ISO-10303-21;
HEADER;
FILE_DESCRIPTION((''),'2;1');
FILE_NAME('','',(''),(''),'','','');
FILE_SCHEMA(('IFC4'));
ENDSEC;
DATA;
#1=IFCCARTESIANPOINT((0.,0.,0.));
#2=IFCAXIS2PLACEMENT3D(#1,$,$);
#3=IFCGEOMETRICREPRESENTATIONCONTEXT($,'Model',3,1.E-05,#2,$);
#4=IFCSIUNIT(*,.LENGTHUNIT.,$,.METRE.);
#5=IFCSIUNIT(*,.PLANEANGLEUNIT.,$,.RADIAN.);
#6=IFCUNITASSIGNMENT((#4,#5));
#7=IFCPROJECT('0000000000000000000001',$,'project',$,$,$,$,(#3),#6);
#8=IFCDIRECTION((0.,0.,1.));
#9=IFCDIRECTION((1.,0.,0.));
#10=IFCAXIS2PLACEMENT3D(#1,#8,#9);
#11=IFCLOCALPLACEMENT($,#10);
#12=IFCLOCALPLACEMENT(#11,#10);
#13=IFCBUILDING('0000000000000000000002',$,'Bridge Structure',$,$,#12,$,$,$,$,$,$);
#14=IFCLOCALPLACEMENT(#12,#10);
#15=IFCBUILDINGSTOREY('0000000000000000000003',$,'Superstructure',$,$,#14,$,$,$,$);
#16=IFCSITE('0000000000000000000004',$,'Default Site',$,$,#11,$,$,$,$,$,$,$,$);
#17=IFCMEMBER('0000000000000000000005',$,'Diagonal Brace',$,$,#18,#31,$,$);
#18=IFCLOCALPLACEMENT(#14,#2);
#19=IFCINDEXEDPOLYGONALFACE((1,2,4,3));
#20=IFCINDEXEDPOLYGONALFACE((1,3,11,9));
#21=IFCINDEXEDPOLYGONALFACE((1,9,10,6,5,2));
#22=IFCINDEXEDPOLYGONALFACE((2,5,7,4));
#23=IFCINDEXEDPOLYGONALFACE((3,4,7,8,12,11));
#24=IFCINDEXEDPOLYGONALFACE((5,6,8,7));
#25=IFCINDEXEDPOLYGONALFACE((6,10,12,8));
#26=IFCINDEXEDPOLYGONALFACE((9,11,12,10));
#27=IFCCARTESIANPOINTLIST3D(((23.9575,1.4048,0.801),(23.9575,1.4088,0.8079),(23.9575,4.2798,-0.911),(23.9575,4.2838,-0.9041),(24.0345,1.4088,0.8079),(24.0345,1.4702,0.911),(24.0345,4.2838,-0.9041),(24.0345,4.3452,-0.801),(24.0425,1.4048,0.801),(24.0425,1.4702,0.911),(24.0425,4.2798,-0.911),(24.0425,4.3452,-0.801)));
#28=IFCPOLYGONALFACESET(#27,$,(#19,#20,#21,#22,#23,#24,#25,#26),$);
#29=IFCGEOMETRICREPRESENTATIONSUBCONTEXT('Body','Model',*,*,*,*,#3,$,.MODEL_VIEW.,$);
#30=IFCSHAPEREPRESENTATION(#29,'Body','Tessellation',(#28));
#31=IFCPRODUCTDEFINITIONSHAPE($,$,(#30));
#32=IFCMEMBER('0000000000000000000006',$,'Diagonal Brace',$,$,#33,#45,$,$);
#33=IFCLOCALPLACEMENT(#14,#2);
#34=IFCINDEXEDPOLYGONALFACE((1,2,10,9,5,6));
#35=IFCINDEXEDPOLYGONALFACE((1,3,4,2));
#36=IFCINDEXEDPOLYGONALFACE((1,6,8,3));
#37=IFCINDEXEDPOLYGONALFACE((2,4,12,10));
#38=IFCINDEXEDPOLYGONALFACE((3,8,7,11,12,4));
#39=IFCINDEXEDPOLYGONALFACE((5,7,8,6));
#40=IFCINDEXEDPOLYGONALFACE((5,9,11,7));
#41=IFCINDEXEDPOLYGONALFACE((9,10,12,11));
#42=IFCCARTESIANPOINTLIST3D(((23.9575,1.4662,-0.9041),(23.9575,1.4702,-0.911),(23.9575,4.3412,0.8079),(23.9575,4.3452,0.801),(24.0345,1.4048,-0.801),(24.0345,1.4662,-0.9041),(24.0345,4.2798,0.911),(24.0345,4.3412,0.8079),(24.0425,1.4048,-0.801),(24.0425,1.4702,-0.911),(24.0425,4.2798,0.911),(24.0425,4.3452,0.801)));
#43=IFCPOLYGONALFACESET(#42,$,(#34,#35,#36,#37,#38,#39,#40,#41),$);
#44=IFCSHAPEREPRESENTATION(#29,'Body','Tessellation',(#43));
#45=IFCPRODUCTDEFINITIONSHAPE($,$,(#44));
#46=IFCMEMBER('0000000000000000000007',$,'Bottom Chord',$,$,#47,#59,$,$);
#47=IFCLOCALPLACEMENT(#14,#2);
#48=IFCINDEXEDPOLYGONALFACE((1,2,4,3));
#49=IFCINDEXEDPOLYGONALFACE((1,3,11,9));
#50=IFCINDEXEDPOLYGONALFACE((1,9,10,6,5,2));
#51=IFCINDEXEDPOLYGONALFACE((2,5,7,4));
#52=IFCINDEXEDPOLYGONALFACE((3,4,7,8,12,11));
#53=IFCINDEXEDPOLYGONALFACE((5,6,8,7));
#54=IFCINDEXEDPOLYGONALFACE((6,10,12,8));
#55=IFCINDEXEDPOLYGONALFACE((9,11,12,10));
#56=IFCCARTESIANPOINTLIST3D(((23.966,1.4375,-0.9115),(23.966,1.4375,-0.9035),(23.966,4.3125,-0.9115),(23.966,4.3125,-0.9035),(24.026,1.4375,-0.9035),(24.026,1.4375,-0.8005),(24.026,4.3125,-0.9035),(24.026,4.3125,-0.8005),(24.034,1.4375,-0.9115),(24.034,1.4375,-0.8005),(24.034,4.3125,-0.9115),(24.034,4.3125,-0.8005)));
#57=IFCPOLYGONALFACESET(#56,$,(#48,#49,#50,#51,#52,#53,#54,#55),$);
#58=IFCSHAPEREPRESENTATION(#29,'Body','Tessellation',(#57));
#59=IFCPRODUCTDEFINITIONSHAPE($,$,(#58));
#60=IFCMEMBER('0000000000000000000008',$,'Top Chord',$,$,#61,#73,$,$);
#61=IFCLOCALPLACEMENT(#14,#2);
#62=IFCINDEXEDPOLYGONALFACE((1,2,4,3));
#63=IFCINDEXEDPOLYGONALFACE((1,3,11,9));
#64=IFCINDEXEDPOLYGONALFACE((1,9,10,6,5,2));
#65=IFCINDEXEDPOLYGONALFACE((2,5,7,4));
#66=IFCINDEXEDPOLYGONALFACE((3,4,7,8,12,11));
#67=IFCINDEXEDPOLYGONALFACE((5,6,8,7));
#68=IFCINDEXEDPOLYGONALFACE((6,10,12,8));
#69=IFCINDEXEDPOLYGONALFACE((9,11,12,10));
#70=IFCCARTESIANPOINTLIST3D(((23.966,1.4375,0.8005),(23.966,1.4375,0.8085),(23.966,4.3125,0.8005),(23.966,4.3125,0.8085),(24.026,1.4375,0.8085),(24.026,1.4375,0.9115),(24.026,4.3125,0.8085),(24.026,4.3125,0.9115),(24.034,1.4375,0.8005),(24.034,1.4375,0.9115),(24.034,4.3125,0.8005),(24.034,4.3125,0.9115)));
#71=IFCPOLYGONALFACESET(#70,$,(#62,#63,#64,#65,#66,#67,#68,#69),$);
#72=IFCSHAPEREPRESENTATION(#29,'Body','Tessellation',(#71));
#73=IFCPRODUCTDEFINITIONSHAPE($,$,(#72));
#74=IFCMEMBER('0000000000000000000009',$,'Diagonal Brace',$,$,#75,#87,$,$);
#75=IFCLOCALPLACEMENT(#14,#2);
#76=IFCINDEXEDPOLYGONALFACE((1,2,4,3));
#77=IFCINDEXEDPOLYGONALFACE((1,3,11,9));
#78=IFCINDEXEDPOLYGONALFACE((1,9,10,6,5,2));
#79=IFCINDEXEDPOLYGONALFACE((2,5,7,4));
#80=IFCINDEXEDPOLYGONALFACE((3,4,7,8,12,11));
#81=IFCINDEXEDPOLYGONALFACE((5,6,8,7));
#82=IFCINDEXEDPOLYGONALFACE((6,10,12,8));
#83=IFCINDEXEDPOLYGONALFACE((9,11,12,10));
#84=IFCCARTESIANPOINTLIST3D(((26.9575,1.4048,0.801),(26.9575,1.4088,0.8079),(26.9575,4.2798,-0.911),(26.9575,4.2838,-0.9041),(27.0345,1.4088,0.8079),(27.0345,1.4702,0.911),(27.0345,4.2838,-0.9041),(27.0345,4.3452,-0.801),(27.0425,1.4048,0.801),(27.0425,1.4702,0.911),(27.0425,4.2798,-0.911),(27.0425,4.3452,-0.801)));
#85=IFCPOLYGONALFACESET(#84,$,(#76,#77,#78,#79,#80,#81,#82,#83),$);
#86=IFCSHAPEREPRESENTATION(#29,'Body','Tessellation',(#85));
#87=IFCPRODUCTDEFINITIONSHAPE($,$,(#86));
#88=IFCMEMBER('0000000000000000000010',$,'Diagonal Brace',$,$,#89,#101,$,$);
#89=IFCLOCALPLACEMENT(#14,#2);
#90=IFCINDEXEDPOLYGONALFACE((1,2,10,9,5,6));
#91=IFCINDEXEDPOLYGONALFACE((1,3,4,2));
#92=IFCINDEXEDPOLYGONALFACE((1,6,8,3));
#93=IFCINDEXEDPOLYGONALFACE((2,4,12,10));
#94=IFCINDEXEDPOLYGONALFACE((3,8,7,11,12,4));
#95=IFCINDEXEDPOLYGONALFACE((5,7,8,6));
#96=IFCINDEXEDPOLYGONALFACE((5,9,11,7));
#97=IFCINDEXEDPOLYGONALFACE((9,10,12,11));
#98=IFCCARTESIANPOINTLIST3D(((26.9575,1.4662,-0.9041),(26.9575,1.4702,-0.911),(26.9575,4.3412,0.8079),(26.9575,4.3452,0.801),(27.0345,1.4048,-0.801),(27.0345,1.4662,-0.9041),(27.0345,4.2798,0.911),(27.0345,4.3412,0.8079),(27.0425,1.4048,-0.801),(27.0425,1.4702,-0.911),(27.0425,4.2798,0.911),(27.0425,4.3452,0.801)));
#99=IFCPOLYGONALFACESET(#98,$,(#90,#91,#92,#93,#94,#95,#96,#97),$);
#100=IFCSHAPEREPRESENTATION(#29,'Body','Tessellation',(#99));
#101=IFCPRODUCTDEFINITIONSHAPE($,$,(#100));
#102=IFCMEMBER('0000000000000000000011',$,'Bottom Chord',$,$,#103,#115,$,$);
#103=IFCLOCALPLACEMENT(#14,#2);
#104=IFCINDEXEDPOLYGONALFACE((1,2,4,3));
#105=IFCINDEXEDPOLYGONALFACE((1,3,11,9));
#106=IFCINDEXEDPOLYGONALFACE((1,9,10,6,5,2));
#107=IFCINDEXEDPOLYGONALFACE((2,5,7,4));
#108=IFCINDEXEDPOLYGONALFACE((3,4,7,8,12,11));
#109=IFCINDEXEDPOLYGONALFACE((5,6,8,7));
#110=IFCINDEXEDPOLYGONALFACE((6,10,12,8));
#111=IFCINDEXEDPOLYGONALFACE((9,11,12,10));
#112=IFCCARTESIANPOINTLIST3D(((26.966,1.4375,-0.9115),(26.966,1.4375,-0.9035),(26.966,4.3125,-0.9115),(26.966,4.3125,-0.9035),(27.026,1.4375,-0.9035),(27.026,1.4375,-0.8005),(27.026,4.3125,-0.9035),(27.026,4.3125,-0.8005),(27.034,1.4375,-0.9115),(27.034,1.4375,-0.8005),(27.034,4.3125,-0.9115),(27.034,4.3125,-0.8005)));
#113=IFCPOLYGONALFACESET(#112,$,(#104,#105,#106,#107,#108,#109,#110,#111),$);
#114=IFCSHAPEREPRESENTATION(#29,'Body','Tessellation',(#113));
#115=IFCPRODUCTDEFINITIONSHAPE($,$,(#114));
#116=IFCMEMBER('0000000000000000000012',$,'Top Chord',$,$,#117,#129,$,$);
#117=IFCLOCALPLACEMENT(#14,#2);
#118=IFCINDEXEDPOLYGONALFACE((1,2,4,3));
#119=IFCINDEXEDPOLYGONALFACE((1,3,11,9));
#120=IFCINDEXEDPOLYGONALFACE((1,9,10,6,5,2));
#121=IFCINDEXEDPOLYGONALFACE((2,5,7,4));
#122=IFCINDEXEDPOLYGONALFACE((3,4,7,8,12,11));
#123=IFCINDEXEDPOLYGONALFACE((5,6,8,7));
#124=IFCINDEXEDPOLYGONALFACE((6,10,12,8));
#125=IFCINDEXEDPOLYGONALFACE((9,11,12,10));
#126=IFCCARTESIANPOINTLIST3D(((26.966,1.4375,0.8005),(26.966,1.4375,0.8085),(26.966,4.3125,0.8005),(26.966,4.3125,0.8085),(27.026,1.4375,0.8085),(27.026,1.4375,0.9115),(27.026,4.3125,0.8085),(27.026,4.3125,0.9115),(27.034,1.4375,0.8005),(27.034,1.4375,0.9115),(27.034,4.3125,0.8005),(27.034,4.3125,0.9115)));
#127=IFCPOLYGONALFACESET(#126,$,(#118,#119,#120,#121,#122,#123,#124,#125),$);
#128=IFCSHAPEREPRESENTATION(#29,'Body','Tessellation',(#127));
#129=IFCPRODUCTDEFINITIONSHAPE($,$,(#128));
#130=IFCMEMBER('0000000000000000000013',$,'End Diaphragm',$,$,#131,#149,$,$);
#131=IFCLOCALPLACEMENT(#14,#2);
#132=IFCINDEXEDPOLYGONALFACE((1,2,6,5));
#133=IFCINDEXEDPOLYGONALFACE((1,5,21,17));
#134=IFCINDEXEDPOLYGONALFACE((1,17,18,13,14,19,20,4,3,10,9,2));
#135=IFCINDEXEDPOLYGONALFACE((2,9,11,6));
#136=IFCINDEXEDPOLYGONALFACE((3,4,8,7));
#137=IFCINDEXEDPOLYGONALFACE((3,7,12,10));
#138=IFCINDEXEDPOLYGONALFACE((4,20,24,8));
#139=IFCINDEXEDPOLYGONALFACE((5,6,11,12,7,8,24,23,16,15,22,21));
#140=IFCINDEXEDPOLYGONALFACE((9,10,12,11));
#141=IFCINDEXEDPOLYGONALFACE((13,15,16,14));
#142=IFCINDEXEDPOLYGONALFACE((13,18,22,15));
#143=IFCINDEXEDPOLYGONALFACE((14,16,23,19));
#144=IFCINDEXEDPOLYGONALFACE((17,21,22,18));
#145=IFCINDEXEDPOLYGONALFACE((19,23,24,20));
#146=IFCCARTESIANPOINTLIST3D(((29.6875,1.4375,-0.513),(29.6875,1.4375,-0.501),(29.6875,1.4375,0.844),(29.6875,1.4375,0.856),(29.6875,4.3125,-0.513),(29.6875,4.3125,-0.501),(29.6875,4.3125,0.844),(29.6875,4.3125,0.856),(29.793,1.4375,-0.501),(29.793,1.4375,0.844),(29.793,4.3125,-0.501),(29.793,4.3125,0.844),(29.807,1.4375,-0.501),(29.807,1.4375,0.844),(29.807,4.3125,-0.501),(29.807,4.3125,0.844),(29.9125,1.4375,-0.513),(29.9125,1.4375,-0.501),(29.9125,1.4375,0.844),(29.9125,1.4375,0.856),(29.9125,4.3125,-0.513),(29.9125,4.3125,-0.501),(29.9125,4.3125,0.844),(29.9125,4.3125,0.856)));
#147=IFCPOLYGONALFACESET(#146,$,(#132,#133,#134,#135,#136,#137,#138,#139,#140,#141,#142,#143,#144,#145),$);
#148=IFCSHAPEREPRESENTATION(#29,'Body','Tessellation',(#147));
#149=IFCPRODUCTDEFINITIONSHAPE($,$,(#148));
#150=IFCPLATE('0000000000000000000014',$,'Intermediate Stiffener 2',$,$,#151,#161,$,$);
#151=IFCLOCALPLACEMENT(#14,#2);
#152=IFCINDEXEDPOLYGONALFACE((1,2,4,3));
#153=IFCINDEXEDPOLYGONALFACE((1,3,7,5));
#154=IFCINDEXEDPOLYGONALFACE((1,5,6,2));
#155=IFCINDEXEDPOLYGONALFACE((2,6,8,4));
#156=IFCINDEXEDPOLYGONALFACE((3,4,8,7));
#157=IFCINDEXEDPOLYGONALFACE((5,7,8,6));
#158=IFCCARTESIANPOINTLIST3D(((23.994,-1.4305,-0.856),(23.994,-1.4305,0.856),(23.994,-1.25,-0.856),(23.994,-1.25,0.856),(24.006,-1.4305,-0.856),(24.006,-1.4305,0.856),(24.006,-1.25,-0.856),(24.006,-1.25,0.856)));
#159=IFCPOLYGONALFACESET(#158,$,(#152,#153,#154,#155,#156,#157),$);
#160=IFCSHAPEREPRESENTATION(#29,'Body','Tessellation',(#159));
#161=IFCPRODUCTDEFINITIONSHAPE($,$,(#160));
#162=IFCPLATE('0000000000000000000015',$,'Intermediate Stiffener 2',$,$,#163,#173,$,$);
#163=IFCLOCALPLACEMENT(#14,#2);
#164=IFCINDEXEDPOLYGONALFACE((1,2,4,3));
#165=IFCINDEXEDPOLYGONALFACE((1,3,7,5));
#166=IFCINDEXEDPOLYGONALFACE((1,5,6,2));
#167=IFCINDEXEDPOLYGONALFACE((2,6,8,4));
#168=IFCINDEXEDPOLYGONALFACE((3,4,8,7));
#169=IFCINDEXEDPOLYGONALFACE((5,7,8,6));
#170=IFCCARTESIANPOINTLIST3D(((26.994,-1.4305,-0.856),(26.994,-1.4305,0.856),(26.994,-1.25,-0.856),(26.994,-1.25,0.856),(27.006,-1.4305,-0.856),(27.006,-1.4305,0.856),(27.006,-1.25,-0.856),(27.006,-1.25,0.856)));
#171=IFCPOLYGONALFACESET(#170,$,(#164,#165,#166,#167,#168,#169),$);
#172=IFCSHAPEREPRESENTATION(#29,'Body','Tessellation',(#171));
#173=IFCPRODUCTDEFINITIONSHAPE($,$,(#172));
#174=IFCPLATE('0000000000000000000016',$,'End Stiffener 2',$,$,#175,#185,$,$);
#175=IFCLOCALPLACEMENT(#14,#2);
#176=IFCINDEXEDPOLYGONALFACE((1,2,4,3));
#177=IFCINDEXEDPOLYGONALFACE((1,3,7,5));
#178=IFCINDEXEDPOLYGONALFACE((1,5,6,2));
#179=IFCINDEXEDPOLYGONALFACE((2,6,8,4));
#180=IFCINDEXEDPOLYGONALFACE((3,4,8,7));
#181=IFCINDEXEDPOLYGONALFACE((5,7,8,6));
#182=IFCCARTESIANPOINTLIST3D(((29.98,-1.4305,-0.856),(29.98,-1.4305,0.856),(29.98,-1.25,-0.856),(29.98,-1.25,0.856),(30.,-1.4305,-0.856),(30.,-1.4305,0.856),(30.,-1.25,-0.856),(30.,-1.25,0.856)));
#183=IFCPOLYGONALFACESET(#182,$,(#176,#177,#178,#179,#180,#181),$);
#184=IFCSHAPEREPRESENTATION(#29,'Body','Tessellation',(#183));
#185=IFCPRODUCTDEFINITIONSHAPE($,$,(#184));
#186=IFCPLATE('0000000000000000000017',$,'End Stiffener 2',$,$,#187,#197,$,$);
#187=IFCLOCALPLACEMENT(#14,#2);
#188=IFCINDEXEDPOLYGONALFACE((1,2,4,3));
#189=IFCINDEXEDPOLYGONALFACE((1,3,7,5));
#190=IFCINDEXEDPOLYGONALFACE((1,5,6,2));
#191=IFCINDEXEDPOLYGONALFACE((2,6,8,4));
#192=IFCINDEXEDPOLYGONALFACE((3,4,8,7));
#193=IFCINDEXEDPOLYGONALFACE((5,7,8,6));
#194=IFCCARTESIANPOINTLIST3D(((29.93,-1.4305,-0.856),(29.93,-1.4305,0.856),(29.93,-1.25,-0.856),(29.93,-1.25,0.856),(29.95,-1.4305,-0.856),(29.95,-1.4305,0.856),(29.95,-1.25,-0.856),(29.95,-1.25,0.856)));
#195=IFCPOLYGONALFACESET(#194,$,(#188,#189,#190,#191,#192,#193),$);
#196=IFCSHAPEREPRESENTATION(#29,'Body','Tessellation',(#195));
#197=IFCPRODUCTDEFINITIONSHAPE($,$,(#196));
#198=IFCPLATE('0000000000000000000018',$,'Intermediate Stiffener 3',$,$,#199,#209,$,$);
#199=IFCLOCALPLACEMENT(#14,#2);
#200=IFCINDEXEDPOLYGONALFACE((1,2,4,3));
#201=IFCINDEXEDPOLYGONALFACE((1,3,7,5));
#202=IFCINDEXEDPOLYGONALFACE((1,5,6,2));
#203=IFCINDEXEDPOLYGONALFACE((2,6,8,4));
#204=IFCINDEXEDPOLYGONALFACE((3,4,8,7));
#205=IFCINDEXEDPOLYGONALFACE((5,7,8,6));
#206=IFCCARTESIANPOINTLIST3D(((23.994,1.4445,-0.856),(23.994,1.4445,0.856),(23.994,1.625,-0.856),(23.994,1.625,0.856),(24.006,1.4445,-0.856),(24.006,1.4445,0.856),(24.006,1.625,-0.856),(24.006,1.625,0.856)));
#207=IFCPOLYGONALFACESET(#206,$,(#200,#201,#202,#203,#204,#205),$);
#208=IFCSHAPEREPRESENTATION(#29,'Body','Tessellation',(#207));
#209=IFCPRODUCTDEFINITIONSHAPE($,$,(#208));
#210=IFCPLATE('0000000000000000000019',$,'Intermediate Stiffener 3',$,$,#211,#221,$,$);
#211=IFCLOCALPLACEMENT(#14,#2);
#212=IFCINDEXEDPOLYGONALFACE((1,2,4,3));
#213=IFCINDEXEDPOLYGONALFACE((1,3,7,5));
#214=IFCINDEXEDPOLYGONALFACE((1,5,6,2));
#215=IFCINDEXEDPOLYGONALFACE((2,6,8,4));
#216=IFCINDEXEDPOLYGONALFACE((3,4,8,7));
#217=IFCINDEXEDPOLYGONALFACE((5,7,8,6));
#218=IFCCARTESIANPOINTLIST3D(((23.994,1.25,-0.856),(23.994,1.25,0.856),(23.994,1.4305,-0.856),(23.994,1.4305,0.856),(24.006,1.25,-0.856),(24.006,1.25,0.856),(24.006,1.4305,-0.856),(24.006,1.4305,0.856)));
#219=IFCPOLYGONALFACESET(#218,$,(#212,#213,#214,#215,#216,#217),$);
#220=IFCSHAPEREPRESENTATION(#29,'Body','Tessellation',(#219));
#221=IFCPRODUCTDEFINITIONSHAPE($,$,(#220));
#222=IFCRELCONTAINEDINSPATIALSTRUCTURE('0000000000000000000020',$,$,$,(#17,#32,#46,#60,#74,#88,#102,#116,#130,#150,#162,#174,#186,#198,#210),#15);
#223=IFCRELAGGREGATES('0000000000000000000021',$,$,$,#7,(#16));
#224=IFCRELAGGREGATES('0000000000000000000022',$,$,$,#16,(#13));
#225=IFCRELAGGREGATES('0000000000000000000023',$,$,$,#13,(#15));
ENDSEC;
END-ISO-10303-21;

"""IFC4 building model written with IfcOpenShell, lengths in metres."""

from ifc_helpers import new_model, si_unit, frame, origin, origin_with_axes, origin_2d_with_axis, place, context, subcontext, project, spatial, rectangle, i_section, l_section, extrude, element, save


model = new_model("IFC4")

# Units and contexts
model_context = context("Model", 3, precision=1e-05, world=origin())
body_context = subcontext(model_context, "Body", "Model", "MODEL_VIEW")
ifc_project = project(units=[si_unit("LENGTHUNIT", "METRE"), si_unit("PLANEANGLEUNIT", "RADIAN")], contexts=[model_context])

# Site, building, storey
site_placement = place(None, origin_with_axes())
site = spatial("IfcSite", under=ifc_project, at=site_placement, Name="Default Site")
building_placement = place(site_placement, origin_with_axes())
building = spatial("IfcBuilding", under=site, at=building_placement, Name="Bridge Structure")
storey_placement = place(building_placement, origin_with_axes())
storey = spatial("IfcBuildingStorey", under=building, at=storey_placement, Name="Superstructure")

# Members
for number, where, z_axis, x_axis, name in (
    (1, (24.0, 1.4375, 0.856), (0.0, 0.859202, -0.511636), (-1.0, 0.0, 0.0), "Diagonal Brace"),
    (2, (24.0, 1.4375, -0.856), (0.0, 0.859202, 0.511636), (-1.0, 0.0, 0.0), "Diagonal Brace"),
):
    element("IfcMember", number, at=place(storey_placement, frame(where, z_axis=z_axis, x_axis=x_axis)), inside=storey, Name=name, context=body_context, shape_type="SweptSolid", body=[
        extrude(l_section(Depth=0.128, Width=0.085, Thickness=0.008, at=origin_2d_with_axis()), origin_with_axes(), (0.0, 0.0, 1.0), 3.3461),
    ])
for number, where, z_axis, x_axis, name in (
    (3, (24.0, 1.4375, -0.856), (0.0, 1.0, 0.0), (-1.0, 0.0, 0.0), "Bottom Chord"),
    (4, (24.0, 1.4375, 0.856), (0.0, 1.0, 0.0), (-1.0, 0.0, 0.0), "Top Chord"),
):
    element("IfcMember", number, at=place(storey_placement, frame(where, z_axis=z_axis, x_axis=x_axis)), inside=storey, Name=name, context=body_context, shape_type="SweptSolid", body=[
        extrude(l_section(Depth=0.111, Width=0.068, Thickness=0.008, at=origin_2d_with_axis()), origin_with_axes(), (0.0, 0.0, 1.0), 2.875),
    ])
for number, where, z_axis, x_axis, name in (
    (5, (27.0, 1.4375, 0.856), (0.0, 0.859202, -0.511636), (-1.0, 0.0, 0.0), "Diagonal Brace"),
    (6, (27.0, 1.4375, -0.856), (0.0, 0.859202, 0.511636), (-1.0, 0.0, 0.0), "Diagonal Brace"),
):
    element("IfcMember", number, at=place(storey_placement, frame(where, z_axis=z_axis, x_axis=x_axis)), inside=storey, Name=name, context=body_context, shape_type="SweptSolid", body=[
        extrude(l_section(Depth=0.128, Width=0.085, Thickness=0.008, at=origin_2d_with_axis()), origin_with_axes(), (0.0, 0.0, 1.0), 3.3461),
    ])
for number, where, z_axis, x_axis, name in (
    (7, (27.0, 1.4375, -0.856), (0.0, 1.0, 0.0), (-1.0, 0.0, 0.0), "Bottom Chord"),
    (8, (27.0, 1.4375, 0.856), (0.0, 1.0, 0.0), (-1.0, 0.0, 0.0), "Top Chord"),
):
    element("IfcMember", number, at=place(storey_placement, frame(where, z_axis=z_axis, x_axis=x_axis)), inside=storey, Name=name, context=body_context, shape_type="SweptSolid", body=[
        extrude(l_section(Depth=0.111, Width=0.068, Thickness=0.008, at=origin_2d_with_axis()), origin_with_axes(), (0.0, 0.0, 1.0), 2.875),
    ])
member_placement = place(storey_placement, frame((29.8, 1.4375, 0.1715), z_axis=(0.0, 1.0, 0.0), x_axis=(-1.0, 0.0, 0.0)))
element("IfcMember", 9, at=member_placement, inside=storey, Name="End Diaphragm", context=body_context, shape_type="SweptSolid", body=[
    extrude(i_section(OverallWidth=0.225, OverallDepth=1.369, WebThickness=0.014, FlangeThickness=0.012, at=origin_2d_with_axis()), origin_with_axes(), (0.0, 0.0, 1.0), 2.875),
])

# Plates
for number, where, z_axis, x_axis, name in (
    (10, (24.0, -1.3402, -0.856), (0.0, 0.0, 1.0), (1.0, 0.0, 0.0), "Intermediate Stiffener 2"),
    (11, (27.0, -1.3402, -0.856), (0.0, 0.0, 1.0), (1.0, 0.0, 0.0), "Intermediate Stiffener 2"),
):
    element("IfcPlate", number, at=place(storey_placement, frame(where, z_axis=z_axis, x_axis=x_axis)), inside=storey, Name=name, context=body_context, shape_type="SweptSolid", body=[
        extrude(rectangle(XDim=0.012, YDim=0.1805, at=origin_2d_with_axis()), origin_with_axes(), (0.0, 0.0, 1.0), 1.712),
    ])
for number, where, z_axis, x_axis, name in (
    (12, (29.99, -1.3402, -0.856), (0.0, 0.0, 1.0), (1.0, 0.0, 0.0), "End Stiffener 2"),
    (13, (29.94, -1.3402, -0.856), (0.0, 0.0, 1.0), (1.0, 0.0, 0.0), "End Stiffener 2"),
):
    element("IfcPlate", number, at=place(storey_placement, frame(where, z_axis=z_axis, x_axis=x_axis)), inside=storey, Name=name, context=body_context, shape_type="SweptSolid", body=[
        extrude(rectangle(XDim=0.02, YDim=0.1805, at=origin_2d_with_axis()), origin_with_axes(), (0.0, 0.0, 1.0), 1.712),
    ])
for number, where, z_axis, x_axis, name in (
    (14, (24.0, 1.5348, -0.856), (0.0, 0.0, 1.0), (1.0, 0.0, 0.0), "Intermediate Stiffener 3"),
    (15, (24.0, 1.3402, -0.856), (0.0, 0.0, 1.0), (1.0, 0.0, 0.0), "Intermediate Stiffener 3"),
):
    element("IfcPlate", number, at=place(storey_placement, frame(where, z_axis=z_axis, x_axis=x_axis)), inside=storey, Name=name, context=body_context, shape_type="SweptSolid", body=[
        extrude(rectangle(XDim=0.012, YDim=0.1805, at=origin_2d_with_axis()), origin_with_axes(), (0.0, 0.0, 1.0), 1.712),
    ])

save(model, "model.ifc")
